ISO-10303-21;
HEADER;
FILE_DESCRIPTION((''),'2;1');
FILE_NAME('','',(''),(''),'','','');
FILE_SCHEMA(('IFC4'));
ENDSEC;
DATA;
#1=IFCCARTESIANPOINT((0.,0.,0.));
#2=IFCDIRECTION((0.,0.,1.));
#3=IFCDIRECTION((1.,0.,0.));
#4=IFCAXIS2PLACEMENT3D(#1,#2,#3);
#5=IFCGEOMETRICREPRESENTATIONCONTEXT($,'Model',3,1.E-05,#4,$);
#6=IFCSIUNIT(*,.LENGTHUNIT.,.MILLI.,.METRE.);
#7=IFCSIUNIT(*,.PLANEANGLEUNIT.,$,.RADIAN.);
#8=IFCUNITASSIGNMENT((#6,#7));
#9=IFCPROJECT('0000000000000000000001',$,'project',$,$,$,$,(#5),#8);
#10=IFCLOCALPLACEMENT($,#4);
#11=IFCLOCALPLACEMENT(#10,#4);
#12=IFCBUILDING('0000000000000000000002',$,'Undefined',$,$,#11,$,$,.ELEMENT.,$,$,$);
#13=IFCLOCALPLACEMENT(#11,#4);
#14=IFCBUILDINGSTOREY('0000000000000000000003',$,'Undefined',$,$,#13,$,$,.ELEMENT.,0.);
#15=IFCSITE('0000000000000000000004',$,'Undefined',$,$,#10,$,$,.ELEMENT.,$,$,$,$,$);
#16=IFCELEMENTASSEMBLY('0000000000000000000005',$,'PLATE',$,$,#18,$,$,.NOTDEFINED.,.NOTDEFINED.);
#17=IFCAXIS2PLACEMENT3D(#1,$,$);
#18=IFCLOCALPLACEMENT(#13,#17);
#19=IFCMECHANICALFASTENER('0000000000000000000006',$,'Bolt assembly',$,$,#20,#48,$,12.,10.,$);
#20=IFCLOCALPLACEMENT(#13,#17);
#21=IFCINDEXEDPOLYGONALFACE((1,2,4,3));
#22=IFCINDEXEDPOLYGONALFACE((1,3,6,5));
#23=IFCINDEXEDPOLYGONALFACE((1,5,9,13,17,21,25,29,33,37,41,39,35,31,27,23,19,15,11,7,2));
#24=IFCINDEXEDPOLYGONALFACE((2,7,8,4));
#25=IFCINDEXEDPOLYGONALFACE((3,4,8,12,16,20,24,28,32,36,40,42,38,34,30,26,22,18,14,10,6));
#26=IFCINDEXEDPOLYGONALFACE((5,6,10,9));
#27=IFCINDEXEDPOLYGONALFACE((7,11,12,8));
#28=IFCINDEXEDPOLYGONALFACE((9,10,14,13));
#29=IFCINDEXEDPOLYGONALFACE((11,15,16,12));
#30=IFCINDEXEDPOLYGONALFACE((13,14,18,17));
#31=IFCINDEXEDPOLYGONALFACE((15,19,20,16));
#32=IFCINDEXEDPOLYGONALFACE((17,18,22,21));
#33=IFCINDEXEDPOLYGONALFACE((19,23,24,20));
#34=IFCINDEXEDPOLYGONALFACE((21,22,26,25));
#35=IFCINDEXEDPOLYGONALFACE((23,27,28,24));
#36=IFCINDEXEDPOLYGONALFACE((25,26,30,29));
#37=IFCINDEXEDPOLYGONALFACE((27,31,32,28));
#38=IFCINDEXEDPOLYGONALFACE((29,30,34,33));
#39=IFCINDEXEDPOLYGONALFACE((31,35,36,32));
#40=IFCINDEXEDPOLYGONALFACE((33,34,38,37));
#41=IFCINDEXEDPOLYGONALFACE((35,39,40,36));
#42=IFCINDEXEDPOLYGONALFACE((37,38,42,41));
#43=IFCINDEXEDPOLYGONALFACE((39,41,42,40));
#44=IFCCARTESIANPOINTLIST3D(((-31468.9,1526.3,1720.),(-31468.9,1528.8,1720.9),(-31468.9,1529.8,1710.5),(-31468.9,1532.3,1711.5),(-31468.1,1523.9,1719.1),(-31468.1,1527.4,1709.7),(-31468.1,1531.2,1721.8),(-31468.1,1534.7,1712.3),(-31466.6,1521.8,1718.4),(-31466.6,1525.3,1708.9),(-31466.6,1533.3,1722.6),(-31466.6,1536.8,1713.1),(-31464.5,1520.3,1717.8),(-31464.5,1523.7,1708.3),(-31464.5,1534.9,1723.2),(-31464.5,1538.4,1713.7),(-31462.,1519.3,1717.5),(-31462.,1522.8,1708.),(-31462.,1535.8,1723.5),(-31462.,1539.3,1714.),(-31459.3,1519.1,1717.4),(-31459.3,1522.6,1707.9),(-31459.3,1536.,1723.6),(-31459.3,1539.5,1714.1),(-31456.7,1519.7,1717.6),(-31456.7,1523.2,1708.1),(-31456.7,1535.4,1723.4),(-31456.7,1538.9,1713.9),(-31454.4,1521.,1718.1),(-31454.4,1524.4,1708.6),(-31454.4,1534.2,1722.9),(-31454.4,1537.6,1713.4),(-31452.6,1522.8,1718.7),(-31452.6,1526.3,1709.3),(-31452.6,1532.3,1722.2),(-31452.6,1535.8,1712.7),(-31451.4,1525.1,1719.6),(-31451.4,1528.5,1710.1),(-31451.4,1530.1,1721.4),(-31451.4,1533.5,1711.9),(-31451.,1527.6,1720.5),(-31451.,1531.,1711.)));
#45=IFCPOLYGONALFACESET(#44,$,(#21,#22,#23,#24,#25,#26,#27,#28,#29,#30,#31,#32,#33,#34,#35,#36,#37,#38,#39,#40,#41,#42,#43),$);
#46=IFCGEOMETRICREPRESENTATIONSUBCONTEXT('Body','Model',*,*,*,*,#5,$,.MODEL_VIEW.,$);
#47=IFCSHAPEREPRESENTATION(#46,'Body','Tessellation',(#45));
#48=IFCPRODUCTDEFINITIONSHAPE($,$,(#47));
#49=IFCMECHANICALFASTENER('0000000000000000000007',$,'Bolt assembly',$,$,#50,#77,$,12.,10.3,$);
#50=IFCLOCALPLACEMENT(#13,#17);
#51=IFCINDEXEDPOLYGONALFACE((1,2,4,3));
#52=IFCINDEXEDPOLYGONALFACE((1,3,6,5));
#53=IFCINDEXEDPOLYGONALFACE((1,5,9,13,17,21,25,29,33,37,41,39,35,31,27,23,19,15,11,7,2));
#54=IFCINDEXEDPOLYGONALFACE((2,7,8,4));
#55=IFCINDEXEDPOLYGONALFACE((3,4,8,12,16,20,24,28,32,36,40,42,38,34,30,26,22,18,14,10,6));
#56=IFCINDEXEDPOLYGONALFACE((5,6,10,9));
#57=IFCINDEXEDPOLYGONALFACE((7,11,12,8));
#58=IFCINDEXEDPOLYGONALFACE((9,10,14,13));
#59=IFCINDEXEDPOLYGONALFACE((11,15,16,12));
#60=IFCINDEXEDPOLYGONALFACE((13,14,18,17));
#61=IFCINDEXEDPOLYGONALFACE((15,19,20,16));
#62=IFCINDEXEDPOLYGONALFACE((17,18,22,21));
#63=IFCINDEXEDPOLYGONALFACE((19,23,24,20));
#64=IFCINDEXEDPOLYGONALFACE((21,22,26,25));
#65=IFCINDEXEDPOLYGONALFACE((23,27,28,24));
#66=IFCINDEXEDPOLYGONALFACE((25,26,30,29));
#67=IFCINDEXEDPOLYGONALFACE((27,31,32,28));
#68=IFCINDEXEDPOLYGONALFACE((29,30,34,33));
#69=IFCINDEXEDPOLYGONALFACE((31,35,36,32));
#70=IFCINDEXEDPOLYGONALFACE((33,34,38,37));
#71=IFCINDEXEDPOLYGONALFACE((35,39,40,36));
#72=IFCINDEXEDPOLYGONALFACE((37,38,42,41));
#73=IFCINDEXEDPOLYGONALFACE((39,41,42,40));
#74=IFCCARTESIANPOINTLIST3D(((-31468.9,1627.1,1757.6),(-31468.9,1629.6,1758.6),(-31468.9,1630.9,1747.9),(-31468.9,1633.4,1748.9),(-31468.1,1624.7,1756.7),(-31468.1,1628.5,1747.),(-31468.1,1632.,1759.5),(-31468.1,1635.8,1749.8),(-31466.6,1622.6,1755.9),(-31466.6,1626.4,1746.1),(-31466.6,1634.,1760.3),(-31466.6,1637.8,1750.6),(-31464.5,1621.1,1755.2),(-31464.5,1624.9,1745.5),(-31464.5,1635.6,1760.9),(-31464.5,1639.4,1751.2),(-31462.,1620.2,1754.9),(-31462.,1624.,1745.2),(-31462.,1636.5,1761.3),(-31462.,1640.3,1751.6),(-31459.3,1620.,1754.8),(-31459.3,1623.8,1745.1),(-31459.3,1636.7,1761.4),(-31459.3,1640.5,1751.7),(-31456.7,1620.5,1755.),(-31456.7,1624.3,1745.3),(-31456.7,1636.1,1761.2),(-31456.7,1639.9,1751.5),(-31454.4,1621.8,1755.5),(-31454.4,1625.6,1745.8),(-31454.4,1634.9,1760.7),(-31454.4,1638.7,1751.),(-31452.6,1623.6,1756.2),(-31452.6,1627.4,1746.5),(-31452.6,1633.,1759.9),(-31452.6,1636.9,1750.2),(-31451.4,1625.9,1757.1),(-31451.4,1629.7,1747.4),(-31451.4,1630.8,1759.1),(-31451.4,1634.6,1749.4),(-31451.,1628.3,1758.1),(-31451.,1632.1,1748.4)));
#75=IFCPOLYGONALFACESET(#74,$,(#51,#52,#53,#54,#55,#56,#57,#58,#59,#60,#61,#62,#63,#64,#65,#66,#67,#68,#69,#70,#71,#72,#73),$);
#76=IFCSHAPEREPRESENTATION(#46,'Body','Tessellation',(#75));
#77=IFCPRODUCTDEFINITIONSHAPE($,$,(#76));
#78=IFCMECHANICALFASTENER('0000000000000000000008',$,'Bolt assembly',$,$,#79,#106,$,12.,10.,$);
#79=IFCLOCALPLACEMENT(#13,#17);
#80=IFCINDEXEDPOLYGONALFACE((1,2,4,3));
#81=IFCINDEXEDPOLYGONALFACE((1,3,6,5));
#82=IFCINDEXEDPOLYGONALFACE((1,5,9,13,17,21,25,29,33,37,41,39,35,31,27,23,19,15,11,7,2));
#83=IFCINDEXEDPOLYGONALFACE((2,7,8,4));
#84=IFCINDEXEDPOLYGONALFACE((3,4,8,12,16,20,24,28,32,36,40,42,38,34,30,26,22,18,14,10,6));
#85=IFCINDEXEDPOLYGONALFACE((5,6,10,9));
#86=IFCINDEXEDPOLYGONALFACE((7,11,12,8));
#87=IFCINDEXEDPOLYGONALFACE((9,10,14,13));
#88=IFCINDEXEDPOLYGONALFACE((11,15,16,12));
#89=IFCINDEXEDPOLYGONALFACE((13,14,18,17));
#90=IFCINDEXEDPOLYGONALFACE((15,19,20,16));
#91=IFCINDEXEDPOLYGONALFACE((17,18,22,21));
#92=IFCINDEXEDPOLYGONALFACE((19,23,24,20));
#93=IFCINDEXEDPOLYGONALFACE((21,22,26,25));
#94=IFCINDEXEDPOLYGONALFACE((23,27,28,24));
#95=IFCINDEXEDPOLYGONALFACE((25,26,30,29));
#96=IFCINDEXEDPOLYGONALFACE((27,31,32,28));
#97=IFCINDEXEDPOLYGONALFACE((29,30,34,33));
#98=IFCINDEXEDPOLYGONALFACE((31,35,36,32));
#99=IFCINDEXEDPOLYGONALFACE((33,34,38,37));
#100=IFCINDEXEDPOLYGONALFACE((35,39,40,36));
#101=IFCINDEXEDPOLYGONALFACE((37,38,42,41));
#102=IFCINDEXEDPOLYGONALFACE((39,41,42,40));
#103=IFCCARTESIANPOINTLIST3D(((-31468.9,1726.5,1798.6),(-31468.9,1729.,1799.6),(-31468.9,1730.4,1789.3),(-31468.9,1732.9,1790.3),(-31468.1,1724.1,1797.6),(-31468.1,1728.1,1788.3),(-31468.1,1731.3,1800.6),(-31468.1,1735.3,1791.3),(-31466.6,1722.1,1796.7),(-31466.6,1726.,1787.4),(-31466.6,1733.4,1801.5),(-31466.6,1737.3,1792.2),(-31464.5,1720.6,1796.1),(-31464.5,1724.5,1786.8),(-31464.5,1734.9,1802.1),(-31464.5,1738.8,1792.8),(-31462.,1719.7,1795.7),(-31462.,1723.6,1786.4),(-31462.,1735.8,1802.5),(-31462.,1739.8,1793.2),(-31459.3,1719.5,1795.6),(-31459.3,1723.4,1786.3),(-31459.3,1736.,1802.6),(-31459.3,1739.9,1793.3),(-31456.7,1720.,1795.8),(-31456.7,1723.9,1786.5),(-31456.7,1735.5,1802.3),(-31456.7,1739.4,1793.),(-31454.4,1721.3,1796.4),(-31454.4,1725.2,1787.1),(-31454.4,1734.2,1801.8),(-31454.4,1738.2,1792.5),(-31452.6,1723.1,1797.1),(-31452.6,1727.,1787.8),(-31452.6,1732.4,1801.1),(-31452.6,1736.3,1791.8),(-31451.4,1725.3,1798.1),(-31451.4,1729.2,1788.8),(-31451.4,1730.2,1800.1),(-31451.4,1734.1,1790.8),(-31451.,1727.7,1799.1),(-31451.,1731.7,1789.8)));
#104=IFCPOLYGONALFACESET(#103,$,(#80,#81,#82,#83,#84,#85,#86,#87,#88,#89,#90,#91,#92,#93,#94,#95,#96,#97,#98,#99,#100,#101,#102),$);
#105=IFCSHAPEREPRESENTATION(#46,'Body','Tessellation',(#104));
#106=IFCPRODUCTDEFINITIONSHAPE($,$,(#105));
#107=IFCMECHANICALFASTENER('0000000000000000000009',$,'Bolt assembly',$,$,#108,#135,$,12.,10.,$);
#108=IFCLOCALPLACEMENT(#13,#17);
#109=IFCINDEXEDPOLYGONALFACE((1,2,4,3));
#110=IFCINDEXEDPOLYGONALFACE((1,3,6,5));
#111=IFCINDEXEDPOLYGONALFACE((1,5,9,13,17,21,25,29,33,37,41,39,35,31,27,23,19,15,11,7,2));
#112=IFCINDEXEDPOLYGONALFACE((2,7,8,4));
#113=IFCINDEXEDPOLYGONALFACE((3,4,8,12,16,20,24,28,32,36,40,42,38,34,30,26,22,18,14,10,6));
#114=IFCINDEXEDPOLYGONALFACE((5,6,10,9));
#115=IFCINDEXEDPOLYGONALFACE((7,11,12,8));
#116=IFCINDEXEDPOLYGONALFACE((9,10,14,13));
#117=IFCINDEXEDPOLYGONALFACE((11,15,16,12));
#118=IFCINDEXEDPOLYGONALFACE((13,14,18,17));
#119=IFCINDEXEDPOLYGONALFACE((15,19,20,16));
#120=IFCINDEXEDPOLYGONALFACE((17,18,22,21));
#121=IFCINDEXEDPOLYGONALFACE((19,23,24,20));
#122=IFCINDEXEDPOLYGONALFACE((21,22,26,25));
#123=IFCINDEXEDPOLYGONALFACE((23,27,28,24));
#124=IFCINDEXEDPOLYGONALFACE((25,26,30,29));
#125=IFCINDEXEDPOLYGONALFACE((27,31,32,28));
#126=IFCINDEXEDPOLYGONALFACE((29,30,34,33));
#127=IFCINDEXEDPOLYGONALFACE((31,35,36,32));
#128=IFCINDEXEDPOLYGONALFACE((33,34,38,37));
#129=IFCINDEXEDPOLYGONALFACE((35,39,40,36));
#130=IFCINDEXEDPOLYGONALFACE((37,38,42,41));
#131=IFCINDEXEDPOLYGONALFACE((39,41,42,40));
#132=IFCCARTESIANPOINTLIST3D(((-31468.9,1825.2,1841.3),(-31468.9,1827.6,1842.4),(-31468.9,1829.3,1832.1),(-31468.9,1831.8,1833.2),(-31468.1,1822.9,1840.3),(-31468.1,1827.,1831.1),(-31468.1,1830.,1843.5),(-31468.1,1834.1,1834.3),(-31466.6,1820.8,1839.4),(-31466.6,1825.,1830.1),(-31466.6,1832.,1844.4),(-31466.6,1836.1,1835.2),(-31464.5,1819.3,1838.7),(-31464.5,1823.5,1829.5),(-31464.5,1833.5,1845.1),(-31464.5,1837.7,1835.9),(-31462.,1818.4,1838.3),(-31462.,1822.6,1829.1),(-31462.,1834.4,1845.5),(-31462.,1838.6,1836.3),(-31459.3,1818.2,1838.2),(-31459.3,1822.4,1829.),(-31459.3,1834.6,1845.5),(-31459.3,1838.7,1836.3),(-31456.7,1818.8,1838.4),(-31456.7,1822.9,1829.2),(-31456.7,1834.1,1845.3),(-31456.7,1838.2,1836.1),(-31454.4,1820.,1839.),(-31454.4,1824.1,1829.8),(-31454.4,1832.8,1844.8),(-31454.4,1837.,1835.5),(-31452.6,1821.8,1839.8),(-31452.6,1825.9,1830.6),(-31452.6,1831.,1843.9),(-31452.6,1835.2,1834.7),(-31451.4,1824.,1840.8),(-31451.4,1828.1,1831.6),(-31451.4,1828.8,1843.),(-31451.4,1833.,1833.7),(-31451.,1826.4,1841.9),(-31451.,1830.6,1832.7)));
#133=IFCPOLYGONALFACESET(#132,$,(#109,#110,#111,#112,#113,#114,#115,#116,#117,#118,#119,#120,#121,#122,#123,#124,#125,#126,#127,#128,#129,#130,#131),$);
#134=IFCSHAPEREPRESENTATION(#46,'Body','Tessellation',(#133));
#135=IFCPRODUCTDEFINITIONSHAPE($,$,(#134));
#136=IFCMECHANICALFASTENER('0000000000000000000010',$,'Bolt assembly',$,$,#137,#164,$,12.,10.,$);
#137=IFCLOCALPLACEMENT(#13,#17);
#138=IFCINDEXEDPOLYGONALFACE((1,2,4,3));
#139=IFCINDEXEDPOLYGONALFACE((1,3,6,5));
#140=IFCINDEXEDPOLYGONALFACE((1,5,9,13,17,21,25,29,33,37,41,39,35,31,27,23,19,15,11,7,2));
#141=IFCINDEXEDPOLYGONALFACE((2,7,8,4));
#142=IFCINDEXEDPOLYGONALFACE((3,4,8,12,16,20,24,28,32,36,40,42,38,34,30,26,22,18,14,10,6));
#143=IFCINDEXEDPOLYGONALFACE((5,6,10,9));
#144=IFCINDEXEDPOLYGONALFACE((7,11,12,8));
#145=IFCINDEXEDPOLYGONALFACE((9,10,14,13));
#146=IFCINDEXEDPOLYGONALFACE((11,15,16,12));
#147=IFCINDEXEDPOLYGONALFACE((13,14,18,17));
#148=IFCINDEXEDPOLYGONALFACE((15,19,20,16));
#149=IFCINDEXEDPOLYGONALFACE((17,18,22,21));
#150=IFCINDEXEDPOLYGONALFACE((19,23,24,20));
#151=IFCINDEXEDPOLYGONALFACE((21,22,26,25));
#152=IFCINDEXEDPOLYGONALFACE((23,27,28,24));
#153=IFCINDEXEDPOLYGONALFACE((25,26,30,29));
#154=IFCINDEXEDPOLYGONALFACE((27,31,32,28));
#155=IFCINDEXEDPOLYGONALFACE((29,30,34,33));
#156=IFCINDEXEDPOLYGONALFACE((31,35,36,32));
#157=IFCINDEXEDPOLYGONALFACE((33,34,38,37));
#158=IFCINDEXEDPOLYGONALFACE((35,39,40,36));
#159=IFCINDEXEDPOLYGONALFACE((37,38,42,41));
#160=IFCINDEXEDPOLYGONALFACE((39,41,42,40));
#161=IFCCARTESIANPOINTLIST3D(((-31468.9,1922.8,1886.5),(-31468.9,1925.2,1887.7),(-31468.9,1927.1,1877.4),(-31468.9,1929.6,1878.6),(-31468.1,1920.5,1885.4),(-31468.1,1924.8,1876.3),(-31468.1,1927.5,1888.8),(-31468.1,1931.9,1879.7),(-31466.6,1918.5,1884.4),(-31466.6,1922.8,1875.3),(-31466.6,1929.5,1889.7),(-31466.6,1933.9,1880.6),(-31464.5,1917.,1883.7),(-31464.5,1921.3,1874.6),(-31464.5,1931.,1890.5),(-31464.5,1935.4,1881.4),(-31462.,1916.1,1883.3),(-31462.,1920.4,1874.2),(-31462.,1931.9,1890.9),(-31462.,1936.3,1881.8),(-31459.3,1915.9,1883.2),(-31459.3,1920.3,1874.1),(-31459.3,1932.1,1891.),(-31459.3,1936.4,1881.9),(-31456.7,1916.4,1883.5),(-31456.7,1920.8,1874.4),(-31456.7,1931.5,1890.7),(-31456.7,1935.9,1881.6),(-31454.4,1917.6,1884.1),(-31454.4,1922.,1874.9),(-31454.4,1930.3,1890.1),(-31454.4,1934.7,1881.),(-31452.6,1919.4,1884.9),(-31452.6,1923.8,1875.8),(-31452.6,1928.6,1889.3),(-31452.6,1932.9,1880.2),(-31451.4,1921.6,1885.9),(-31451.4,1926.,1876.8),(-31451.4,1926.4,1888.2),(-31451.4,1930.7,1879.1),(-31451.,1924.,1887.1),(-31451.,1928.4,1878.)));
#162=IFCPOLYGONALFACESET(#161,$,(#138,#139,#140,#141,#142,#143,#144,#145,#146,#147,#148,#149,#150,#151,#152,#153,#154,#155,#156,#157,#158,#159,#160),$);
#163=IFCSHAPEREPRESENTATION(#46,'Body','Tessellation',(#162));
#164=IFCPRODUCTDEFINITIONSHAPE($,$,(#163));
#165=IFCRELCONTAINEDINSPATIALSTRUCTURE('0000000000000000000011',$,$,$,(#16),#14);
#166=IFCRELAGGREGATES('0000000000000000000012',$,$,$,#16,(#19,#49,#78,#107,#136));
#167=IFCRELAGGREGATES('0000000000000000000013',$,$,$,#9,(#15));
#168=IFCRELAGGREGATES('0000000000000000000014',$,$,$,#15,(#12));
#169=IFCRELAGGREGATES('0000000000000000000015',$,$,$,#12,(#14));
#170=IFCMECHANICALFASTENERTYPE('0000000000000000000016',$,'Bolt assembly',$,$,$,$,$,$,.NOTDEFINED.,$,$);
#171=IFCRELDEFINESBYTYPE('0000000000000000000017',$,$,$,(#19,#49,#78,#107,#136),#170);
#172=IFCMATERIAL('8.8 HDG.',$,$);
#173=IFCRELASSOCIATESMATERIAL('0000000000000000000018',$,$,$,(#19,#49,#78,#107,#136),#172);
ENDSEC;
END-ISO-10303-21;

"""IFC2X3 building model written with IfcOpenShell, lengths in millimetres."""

from ifc_helpers import new_model, si_unit, frame, origin_with_axes, origin_2d_with_axis, place, context, subcontext, project, spatial, circle, extrude, source, transform, mapped, material, type_object, element, aggregate, save


model = new_model("IFC2X3")

# Units and contexts
model_context = context("Model", 3, precision=1e-05, world=origin_with_axes())
body_context = subcontext(model_context, "Body", "Model", "MODEL_VIEW")
ifc_project = project(units=[si_unit("LENGTHUNIT", "METRE", prefix="MILLI"), si_unit("PLANEANGLEUNIT", "RADIAN")], contexts=[model_context])

# Site, building, storey
site_placement = place(None, origin_with_axes())
site = spatial("IfcSite", under=ifc_project, at=site_placement, Name="Undefined", CompositionType="ELEMENT")
building_placement = place(site_placement, origin_with_axes())
building = spatial("IfcBuilding", under=site, at=building_placement, Name="Undefined", CompositionType="ELEMENT")
storey_placement = place(building_placement, origin_with_axes())
storey = spatial("IfcBuildingStorey", under=building, at=storey_placement, Name="Undefined", CompositionType="ELEMENT", Elevation=0.0)

# Element assembly, mechanical fasteners
assembly_placement = place(storey_placement, origin_with_axes())
assembly = element("IfcElementAssembly", 1, at=assembly_placement, inside=storey, Name="PLATE", AssemblyPlace="NOTDEFINED", PredefinedType="NOTDEFINED")
ifc_material_1 = material(Name="8.8 HDG.")
mechanical_fastener_type = type_object("IfcMechanicalFastenerType", Name="Bolt assembly")
shared_shape_1 = source(origin_with_axes(), body_context, "Body", "SweptSolid", [
    extrude(circle(Radius=9.0, at=origin_2d_with_axis()), frame((0.0, 0.9, 0.0), z_axis=(0.0, 1.0, 0.0), x_axis=(1.0, 0.0, 0.0)), (0.0, 0.0, 1.0), 10.1),
])
mechanical_fastener_1_placement = place(assembly_placement, frame((-31460.0, 1531.4, 1710.1), z_axis=(0.000001, -0.939233, -0.343282), x_axis=(1.0, 0.000001, 0.0)))
mechanical_fastener_1 = element("IfcMechanicalFastener", 2, at=mechanical_fastener_1_placement, type_object=mechanical_fastener_type, material=ifc_material_1, Name="Bolt assembly", NominalDiameter=12.0, NominalLength=10.0, context=body_context, shape_type="MappedRepresentation", body=[
    mapped(shared_shape_1, transform((0.0, 0.0, 0.0))),
])
shared_shape_2 = source(origin_with_axes(), body_context, "Body", "SweptSolid", [
    extrude(circle(Radius=9.0, at=origin_2d_with_axis()), frame((0.0, 0.0, 0.0), z_axis=(0.0, 1.0, 0.0), x_axis=(1.0, 0.0, 0.0)), (0.0, 0.0, 1.0), 10.4),
])
mechanical_fastener_2_placement = place(assembly_placement, frame((-31460.0, 1632.2, 1748.4), z_axis=(0.000001, -0.930663, -0.365877), x_axis=(1.0, 0.000001, 0.0)))
mechanical_fastener_2 = element("IfcMechanicalFastener", 3, at=mechanical_fastener_2_placement, type_object=mechanical_fastener_type, material=ifc_material_1, Name="Bolt assembly", NominalDiameter=12.0, NominalLength=10.3, context=body_context, shape_type="MappedRepresentation", body=[
    mapped(shared_shape_2, transform((0.0, 0.0, 0.0))),
])
shared_shape_3 = source(origin_with_axes(), body_context, "Body", "SweptSolid", [
    extrude(circle(Radius=9.0, at=origin_2d_with_axis()), frame((0.0, 0.8, 0.0), z_axis=(0.0, 1.0, 0.0), x_axis=(1.0, 0.0, 0.0)), (0.0, 0.0, 1.0), 10.1),
])
mechanical_fastener_3_placement = place(assembly_placement, frame((-31460.0, 1732.0, 1789.0), z_axis=(0.000001, -0.921551, -0.388258), x_axis=(1.0, 0.000001, 0.0)))
mechanical_fastener_3 = element("IfcMechanicalFastener", 4, at=mechanical_fastener_3_placement, type_object=mechanical_fastener_type, material=ifc_material_1, Name="Bolt assembly", NominalDiameter=12.0, NominalLength=10.0, context=body_context, shape_type="MappedRepresentation", body=[
    mapped(shared_shape_3, transform((0.0, 0.0, 0.0))),
])
shared_shape_4 = source(origin_with_axes(), body_context, "Body", "SweptSolid", [
    extrude(circle(Radius=9.0, at=origin_2d_with_axis()), frame((0.0, 0.7, 0.0), z_axis=(0.0, 1.0, 0.0), x_axis=(1.0, 0.0, 0.0)), (0.0, 0.0, 1.0), 10.1),
])
mechanical_fastener_4_placement = place(assembly_placement, frame((-31460.0, 1830.8, 1832.1), z_axis=(0.000001, -0.9119, -0.410413), x_axis=(1.0, 0.000001, 0.0)))
mechanical_fastener_4 = element("IfcMechanicalFastener", 5, at=mechanical_fastener_4_placement, type_object=mechanical_fastener_type, material=ifc_material_1, Name="Bolt assembly", NominalDiameter=12.0, NominalLength=10.0, context=body_context, shape_type="MappedRepresentation", body=[
    mapped(shared_shape_4, transform((0.0, 0.0, 0.0))),
])
shared_shape_5 = source(origin_with_axes(), body_context, "Body", "SweptSolid", [
    extrude(circle(Radius=9.0, at=origin_2d_with_axis()), frame((0.0, 0.5, 0.0), z_axis=(0.0, 1.0, 0.0), x_axis=(1.0, 0.0, 0.0)), (0.0, 0.0, 1.0), 10.1),
])
mechanical_fastener_5_placement = place(assembly_placement, frame((-31460.0, 1928.6, 1877.5), z_axis=(0.000001, -0.901716, -0.432328), x_axis=(1.0, 0.000001, 0.0)))
mechanical_fastener_5 = element("IfcMechanicalFastener", 6, at=mechanical_fastener_5_placement, type_object=mechanical_fastener_type, material=ifc_material_1, Name="Bolt assembly", NominalDiameter=12.0, NominalLength=10.0, context=body_context, shape_type="MappedRepresentation", body=[
    mapped(shared_shape_5, transform((0.0, 0.0, 0.0))),
])
aggregate(assembly, [mechanical_fastener_1, mechanical_fastener_2, mechanical_fastener_3, mechanical_fastener_4, mechanical_fastener_5])

save(model, "model.ifc")
